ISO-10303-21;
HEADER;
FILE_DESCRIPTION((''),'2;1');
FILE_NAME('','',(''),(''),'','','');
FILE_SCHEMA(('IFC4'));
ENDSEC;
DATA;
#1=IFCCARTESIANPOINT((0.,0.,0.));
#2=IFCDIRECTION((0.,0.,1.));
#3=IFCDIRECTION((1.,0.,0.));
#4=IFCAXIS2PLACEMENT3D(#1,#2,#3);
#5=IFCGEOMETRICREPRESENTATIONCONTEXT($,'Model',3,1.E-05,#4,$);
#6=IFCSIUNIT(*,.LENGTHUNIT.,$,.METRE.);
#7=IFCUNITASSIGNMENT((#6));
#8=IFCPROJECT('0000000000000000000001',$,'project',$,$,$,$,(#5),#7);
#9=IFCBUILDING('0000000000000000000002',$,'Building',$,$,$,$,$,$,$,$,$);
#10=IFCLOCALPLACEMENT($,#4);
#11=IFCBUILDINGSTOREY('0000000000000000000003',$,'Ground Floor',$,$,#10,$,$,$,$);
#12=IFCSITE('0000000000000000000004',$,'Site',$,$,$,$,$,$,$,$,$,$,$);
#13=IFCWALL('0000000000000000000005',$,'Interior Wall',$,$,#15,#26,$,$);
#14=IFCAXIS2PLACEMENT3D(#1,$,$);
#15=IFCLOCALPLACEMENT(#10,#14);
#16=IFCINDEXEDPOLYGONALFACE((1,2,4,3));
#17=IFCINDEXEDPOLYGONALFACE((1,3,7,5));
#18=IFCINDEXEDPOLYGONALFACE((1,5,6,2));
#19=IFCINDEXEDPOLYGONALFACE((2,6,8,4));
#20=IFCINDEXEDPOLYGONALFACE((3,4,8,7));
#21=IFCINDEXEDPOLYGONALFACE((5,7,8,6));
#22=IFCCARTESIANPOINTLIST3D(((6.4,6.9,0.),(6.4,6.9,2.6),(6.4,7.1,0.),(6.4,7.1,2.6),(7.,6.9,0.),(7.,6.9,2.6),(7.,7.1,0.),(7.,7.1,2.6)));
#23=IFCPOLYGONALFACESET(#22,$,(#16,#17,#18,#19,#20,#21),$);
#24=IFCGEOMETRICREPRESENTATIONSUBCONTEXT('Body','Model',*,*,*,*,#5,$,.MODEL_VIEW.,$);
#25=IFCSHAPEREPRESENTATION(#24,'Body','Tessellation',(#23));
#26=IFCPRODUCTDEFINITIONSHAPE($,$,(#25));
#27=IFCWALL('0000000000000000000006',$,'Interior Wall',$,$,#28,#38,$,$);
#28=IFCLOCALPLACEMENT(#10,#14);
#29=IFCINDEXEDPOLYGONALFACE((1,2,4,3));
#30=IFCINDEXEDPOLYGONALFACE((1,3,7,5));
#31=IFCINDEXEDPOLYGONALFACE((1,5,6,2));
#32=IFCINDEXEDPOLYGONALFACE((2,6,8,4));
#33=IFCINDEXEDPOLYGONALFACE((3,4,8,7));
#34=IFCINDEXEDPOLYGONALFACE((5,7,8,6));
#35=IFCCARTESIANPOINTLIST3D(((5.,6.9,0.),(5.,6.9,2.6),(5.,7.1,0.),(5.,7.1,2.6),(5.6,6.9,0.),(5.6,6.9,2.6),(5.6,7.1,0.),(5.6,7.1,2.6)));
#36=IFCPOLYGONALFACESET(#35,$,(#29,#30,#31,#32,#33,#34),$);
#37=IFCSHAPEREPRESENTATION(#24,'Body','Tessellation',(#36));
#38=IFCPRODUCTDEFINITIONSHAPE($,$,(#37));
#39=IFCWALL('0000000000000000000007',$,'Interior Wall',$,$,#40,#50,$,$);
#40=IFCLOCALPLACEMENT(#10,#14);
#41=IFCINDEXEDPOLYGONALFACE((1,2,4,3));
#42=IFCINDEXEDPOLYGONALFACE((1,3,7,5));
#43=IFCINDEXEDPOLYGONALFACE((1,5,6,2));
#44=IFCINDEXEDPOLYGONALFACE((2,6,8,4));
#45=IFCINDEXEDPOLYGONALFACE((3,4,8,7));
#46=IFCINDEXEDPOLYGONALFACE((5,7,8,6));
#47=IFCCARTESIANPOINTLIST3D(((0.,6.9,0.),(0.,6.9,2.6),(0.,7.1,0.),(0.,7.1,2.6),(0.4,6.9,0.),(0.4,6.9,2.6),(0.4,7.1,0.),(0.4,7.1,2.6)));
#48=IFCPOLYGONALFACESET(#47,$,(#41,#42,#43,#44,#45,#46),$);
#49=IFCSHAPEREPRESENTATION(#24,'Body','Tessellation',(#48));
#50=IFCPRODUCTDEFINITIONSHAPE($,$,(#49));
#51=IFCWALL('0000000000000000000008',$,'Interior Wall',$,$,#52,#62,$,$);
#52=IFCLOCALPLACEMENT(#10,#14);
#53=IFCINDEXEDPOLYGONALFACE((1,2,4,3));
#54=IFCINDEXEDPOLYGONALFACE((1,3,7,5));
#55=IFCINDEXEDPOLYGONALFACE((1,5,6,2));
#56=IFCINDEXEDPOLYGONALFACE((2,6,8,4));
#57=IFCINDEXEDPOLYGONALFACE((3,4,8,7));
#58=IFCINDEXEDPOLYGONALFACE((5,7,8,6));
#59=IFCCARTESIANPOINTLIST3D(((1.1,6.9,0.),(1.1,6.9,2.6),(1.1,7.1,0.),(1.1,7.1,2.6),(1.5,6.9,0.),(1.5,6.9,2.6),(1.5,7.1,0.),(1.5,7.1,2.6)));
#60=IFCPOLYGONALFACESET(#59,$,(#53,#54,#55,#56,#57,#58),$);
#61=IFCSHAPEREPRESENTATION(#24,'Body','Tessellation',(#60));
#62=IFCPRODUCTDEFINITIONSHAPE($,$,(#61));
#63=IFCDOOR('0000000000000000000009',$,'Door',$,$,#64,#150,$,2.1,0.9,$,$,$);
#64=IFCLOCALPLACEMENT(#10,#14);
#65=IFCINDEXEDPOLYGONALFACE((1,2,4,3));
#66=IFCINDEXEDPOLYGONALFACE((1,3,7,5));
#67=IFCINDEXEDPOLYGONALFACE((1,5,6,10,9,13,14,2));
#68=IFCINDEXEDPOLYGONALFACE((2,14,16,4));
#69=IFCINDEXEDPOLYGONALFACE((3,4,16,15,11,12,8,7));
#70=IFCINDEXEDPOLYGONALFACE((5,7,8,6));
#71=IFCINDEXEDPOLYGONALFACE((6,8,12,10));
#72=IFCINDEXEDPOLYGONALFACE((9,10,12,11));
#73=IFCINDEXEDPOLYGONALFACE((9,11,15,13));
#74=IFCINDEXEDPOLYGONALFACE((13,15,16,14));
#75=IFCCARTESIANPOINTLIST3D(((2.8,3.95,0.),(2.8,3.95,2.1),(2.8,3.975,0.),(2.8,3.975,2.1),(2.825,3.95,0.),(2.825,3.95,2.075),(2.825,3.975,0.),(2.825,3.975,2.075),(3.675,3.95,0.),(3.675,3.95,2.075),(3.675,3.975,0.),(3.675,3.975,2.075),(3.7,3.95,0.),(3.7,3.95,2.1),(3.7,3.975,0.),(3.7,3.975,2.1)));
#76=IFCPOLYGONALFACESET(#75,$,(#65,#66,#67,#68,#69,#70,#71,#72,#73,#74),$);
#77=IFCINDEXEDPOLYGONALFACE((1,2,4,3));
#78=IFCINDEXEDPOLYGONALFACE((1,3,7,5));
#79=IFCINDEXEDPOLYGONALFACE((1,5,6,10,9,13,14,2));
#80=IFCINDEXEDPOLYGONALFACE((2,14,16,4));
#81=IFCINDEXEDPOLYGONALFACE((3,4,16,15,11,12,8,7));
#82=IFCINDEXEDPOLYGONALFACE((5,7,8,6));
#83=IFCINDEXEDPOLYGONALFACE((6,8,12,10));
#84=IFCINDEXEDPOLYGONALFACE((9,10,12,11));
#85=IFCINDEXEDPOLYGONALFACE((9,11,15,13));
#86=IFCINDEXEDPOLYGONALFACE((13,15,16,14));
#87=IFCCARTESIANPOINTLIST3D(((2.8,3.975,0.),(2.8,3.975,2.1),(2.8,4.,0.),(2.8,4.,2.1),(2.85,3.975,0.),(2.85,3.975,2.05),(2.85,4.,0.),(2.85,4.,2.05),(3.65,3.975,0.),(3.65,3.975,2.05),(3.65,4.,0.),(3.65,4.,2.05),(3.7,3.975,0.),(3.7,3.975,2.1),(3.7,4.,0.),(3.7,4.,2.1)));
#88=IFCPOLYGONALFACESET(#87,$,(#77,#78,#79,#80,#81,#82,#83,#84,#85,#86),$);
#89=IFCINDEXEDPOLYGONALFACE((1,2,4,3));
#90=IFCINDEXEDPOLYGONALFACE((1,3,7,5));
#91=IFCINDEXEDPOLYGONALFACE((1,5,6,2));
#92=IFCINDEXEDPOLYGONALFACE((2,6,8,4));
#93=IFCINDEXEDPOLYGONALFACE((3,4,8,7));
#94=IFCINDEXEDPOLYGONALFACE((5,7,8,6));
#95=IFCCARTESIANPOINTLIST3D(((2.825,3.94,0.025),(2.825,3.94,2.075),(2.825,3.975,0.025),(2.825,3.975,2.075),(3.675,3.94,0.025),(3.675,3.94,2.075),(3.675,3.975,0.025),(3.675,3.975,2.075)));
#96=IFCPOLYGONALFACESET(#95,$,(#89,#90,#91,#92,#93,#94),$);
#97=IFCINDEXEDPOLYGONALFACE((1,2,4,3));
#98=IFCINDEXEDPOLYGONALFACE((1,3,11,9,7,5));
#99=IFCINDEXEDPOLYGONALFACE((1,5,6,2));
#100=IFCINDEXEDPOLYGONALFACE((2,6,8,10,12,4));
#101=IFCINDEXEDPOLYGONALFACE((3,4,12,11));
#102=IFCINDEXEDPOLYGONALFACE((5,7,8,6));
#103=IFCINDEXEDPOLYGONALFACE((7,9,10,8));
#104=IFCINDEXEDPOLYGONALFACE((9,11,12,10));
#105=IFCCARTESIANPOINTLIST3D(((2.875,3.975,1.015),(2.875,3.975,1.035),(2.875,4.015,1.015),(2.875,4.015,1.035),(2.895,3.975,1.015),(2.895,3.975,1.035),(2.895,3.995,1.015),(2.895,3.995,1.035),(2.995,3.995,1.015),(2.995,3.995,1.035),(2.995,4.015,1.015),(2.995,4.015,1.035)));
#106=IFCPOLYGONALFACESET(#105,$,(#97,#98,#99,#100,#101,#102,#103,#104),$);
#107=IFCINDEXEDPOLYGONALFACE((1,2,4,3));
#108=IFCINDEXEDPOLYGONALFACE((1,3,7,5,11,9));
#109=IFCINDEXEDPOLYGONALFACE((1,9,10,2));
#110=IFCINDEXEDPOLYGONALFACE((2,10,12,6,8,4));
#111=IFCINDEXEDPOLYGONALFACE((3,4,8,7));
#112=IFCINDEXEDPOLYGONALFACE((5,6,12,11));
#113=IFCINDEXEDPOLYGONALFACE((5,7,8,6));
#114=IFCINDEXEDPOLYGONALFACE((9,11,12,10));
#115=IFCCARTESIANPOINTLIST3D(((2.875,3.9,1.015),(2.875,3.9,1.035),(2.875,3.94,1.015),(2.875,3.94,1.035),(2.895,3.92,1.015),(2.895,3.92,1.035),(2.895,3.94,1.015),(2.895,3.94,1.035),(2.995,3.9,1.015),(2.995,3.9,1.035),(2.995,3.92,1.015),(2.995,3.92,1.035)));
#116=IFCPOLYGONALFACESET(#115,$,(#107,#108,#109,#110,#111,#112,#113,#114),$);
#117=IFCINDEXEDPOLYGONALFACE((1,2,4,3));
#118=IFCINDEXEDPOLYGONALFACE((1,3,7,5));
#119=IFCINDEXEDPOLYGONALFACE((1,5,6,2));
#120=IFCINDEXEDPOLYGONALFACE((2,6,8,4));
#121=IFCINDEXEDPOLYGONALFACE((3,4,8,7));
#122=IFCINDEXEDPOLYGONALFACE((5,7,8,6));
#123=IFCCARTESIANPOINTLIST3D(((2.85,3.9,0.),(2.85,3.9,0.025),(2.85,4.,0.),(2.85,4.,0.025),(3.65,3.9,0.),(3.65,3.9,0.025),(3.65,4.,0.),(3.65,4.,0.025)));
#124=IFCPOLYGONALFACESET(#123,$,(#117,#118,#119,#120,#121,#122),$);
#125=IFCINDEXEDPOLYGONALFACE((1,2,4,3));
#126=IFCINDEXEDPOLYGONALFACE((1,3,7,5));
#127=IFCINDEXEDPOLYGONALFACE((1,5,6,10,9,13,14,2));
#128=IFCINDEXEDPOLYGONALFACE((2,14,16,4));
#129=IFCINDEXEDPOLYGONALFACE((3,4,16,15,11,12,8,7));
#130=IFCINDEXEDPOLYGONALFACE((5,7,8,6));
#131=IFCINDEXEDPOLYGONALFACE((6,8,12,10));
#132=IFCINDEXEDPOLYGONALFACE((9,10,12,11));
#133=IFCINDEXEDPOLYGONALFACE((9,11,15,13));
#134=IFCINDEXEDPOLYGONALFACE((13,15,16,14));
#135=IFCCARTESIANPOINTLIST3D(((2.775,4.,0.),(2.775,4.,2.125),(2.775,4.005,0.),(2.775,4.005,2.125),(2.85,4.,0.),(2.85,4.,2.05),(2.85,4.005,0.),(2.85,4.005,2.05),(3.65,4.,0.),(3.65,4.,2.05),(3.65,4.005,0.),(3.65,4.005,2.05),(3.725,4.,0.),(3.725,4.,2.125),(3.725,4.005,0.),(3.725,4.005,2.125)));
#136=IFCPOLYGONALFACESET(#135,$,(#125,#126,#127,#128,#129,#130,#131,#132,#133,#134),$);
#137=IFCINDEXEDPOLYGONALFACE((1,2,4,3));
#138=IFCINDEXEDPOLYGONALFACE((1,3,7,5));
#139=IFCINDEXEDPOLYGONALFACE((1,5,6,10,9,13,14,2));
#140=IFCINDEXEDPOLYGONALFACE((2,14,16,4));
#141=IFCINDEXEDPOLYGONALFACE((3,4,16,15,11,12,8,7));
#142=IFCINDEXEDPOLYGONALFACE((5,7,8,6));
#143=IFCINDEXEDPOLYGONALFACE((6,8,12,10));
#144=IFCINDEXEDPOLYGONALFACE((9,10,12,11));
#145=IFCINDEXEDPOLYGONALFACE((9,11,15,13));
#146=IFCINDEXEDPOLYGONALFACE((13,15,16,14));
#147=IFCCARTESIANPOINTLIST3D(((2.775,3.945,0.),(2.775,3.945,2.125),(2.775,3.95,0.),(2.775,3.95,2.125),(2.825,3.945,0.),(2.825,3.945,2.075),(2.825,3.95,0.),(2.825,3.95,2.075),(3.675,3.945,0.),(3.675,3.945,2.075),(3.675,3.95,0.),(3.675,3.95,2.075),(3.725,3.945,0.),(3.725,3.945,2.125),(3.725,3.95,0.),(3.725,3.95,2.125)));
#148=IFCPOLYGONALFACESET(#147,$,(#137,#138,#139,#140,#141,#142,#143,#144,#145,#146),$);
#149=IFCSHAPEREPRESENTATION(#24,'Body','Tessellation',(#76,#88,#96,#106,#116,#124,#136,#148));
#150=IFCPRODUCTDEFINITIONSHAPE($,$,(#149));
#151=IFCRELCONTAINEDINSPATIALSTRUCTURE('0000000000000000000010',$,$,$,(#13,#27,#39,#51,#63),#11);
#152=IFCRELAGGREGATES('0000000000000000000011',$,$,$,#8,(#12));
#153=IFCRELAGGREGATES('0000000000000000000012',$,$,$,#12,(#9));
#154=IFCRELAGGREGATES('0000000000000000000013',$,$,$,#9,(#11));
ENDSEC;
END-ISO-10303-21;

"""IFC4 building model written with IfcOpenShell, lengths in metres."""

from ifc_helpers import new_model, si_unit, frame, origin_with_axes, place, context, subcontext, project, spatial, line, indexed_curve, outline, extrude, element, save


model = new_model("IFC4")

# Units and contexts
model_context = context("Model", 3, precision=1e-05, world=origin_with_axes())
body_context = subcontext(model_context, "Body", "Model", "MODEL_VIEW")
ifc_project = project(units=[si_unit("LENGTHUNIT", "METRE")], contexts=[model_context])

# Site, building, storey
site = spatial("IfcSite", under=ifc_project, Name="Site")
building = spatial("IfcBuilding", under=site, Name="Building")
storey_placement = place(None, origin_with_axes())
storey = spatial("IfcBuildingStorey", under=building, at=storey_placement, Name="Ground Floor")

# Walls
for number, where, z_axis, x_axis, name in (
    (1, (7.0, 7.0, 0.0), (0.0, 0.0, 1.0), (-1.0, 0.0, 0.0), "Interior Wall"),
    (2, (5.6, 7.0, 0.0), (0.0, 0.0, 1.0), (-1.0, 0.0, 0.0), "Interior Wall"),
):
    element("IfcWall", number, at=place(storey_placement, frame(where, z_axis=z_axis, x_axis=x_axis)), inside=storey, Name=name, context=body_context, shape_type="SweptSolid", body=[
        extrude(outline(indexed_curve([(0.0, 0.0), (0.0, 0.2), (0.6, 0.2), (0.6, 0.0), (0.0, 0.0)], self_intersect=False)), frame((0.0, -0.1, 0.0), z_axis=(0.0, 0.0, 1.0), x_axis=(1.0, 0.0, 0.0)), (0.0, 0.0, 1.0), 2.6),
    ])
wall_1_placement = place(storey_placement, frame((0.0, 7.0, 0.0), z_axis=(0.0, 0.0, 1.0), x_axis=(1.0, 0.0, 0.0)))
element("IfcWall", 3, at=wall_1_placement, inside=storey, Name="Interior Wall", context=body_context, shape_type="SweptSolid", body=[
    extrude(outline(indexed_curve([(0.0, 0.0), (0.0, 0.2), (0.4, 0.2), (0.4, 0.0), (0.0, 0.0)], self_intersect=False)), frame((0.0, -0.1, 0.0), z_axis=(0.0, 0.0, 1.0), x_axis=(1.0, 0.0, 0.0)), (0.0, 0.0, 1.0), 2.6),
])
wall_2_placement = place(storey_placement, frame((1.1, 7.0, 0.0), z_axis=(0.0, 0.0, 1.0), x_axis=(1.0, 0.0, 0.0)))
element("IfcWall", 4, at=wall_2_placement, inside=storey, Name="Interior Wall", context=body_context, shape_type="SweptSolid", body=[
    extrude(outline(indexed_curve([(0.0, 0.0), (0.0, 0.2), (0.4, 0.2), (0.4, 0.0), (0.0, 0.0)], self_intersect=False)), frame((0.0, -0.1, 0.0), z_axis=(0.0, 0.0, 1.0), x_axis=(1.0, 0.0, 0.0)), (0.0, 0.0, 1.0), 2.6),
])

# Door
door_1_placement = place(storey_placement, frame((3.7, 4.0, 0.0), z_axis=(0.0, 0.0, 1.0), x_axis=(-1.0, 0.0, 0.0)))
element("IfcDoor", 5, at=door_1_placement, inside=storey, Name="Door", OverallHeight=2.1, OverallWidth=0.9, context=body_context, shape_type="SweptSolid", body=[
    extrude(outline(indexed_curve([(0.0, 0.0), (0.0, 2.1), (0.9, 2.1), (0.9, 0.0), (0.875, 0.0), (0.875, 2.075), (0.025, 2.075), (0.025, 0.0)], segments=[line(1, 2, 3, 4, 5, 6, 7, 8, 1)])), frame((0.0, 0.025, 0.0), z_axis=(0.0, -1.0, 0.0), x_axis=(1.0, 0.0, 0.0)), (0.0, 0.0, -1.0), 0.025),
    extrude(outline(indexed_curve([(0.0, 0.0), (0.0, 2.1), (0.9, 2.1), (0.9, 0.0), (0.85, 0.0), (0.85, 2.05), (0.05, 2.05), (0.05, 0.0)], segments=[line(1, 2, 3, 4, 5, 6, 7, 8, 1)])), frame((0.0, 0.0, 0.0), z_axis=(0.0, -1.0, 0.0), x_axis=(1.0, 0.0, 0.0)), (0.0, 0.0, -1.0), 0.025),
    extrude(outline(indexed_curve([(0.0, 0.0), (0.85, 0.0), (0.85, 0.035), (0.0, 0.035)], segments=[line(1, 2, 3, 4, 1)])), frame((0.025, 0.025, 0.025), z_axis=(0.0, 0.0, 1.0), x_axis=(1.0, 0.0, 0.0)), (0.0, 0.0, 1.0), 2.05),
    extrude(outline(indexed_curve([(0.0, 0.0), (0.0, -0.04), (-0.12, -0.04), (-0.12, -0.02), (-0.02, -0.02), (-0.02, 0.0)], segments=[line(1, 2, 3, 4, 5, 6, 1)])), frame((0.825, 0.025, 1.015), z_axis=(0.0, 0.0, 1.0), x_axis=(1.0, 0.0, 0.0)), (0.0, 0.0, 1.0), 0.02),
    extrude(outline(indexed_curve([(0.0, 0.0), (0.0, 0.04), (-0.12, 0.04), (-0.12, 0.02), (-0.02, 0.02), (-0.02, 0.0)], segments=[line(1, 2, 3, 4, 5, 6, 1)])), frame((0.825, 0.06, 1.015), z_axis=(0.0, 0.0, 1.0), x_axis=(1.0, 0.0, 0.0)), (0.0, 0.0, 1.0), 0.02),
    extrude(outline(indexed_curve([(0.0, 0.0), (0.8, 0.0), (0.8, 0.1), (0.0, 0.1)], segments=[line(1, 2, 3, 4, 1)])), frame((0.05, 0.0, 0.0), z_axis=(0.0, 0.0, 1.0), x_axis=(1.0, 0.0, 0.0)), (0.0, 0.0, 1.0), 0.025),
    extrude(outline(indexed_curve([(0.0, 0.0), (0.0, 2.125), (0.95, 2.125), (0.95, 0.0), (0.875, 0.0), (0.875, 2.05), (0.075, 2.05), (0.075, 0.0)], segments=[line(1, 2, 3, 4, 5, 6, 7, 8, 1)])), frame((-0.025, -0.005, 0.0), z_axis=(0.0, -1.0, 0.0), x_axis=(1.0, 0.0, 0.0)), (0.0, 0.0, -1.0), 0.005),
    extrude(outline(indexed_curve([(0.0, 0.0), (0.0, 2.125), (0.95, 2.125), (0.95, 0.0), (0.9, 0.0), (0.9, 2.075), (0.05, 2.075), (0.05, 0.0)], segments=[line(1, 2, 3, 4, 5, 6, 7, 8, 1)])), frame((-0.025, 0.05, 0.0), z_axis=(0.0, -1.0, 0.0), x_axis=(1.0, 0.0, 0.0)), (0.0, 0.0, -1.0), 0.005),
])

save(model, "model.ifc")
